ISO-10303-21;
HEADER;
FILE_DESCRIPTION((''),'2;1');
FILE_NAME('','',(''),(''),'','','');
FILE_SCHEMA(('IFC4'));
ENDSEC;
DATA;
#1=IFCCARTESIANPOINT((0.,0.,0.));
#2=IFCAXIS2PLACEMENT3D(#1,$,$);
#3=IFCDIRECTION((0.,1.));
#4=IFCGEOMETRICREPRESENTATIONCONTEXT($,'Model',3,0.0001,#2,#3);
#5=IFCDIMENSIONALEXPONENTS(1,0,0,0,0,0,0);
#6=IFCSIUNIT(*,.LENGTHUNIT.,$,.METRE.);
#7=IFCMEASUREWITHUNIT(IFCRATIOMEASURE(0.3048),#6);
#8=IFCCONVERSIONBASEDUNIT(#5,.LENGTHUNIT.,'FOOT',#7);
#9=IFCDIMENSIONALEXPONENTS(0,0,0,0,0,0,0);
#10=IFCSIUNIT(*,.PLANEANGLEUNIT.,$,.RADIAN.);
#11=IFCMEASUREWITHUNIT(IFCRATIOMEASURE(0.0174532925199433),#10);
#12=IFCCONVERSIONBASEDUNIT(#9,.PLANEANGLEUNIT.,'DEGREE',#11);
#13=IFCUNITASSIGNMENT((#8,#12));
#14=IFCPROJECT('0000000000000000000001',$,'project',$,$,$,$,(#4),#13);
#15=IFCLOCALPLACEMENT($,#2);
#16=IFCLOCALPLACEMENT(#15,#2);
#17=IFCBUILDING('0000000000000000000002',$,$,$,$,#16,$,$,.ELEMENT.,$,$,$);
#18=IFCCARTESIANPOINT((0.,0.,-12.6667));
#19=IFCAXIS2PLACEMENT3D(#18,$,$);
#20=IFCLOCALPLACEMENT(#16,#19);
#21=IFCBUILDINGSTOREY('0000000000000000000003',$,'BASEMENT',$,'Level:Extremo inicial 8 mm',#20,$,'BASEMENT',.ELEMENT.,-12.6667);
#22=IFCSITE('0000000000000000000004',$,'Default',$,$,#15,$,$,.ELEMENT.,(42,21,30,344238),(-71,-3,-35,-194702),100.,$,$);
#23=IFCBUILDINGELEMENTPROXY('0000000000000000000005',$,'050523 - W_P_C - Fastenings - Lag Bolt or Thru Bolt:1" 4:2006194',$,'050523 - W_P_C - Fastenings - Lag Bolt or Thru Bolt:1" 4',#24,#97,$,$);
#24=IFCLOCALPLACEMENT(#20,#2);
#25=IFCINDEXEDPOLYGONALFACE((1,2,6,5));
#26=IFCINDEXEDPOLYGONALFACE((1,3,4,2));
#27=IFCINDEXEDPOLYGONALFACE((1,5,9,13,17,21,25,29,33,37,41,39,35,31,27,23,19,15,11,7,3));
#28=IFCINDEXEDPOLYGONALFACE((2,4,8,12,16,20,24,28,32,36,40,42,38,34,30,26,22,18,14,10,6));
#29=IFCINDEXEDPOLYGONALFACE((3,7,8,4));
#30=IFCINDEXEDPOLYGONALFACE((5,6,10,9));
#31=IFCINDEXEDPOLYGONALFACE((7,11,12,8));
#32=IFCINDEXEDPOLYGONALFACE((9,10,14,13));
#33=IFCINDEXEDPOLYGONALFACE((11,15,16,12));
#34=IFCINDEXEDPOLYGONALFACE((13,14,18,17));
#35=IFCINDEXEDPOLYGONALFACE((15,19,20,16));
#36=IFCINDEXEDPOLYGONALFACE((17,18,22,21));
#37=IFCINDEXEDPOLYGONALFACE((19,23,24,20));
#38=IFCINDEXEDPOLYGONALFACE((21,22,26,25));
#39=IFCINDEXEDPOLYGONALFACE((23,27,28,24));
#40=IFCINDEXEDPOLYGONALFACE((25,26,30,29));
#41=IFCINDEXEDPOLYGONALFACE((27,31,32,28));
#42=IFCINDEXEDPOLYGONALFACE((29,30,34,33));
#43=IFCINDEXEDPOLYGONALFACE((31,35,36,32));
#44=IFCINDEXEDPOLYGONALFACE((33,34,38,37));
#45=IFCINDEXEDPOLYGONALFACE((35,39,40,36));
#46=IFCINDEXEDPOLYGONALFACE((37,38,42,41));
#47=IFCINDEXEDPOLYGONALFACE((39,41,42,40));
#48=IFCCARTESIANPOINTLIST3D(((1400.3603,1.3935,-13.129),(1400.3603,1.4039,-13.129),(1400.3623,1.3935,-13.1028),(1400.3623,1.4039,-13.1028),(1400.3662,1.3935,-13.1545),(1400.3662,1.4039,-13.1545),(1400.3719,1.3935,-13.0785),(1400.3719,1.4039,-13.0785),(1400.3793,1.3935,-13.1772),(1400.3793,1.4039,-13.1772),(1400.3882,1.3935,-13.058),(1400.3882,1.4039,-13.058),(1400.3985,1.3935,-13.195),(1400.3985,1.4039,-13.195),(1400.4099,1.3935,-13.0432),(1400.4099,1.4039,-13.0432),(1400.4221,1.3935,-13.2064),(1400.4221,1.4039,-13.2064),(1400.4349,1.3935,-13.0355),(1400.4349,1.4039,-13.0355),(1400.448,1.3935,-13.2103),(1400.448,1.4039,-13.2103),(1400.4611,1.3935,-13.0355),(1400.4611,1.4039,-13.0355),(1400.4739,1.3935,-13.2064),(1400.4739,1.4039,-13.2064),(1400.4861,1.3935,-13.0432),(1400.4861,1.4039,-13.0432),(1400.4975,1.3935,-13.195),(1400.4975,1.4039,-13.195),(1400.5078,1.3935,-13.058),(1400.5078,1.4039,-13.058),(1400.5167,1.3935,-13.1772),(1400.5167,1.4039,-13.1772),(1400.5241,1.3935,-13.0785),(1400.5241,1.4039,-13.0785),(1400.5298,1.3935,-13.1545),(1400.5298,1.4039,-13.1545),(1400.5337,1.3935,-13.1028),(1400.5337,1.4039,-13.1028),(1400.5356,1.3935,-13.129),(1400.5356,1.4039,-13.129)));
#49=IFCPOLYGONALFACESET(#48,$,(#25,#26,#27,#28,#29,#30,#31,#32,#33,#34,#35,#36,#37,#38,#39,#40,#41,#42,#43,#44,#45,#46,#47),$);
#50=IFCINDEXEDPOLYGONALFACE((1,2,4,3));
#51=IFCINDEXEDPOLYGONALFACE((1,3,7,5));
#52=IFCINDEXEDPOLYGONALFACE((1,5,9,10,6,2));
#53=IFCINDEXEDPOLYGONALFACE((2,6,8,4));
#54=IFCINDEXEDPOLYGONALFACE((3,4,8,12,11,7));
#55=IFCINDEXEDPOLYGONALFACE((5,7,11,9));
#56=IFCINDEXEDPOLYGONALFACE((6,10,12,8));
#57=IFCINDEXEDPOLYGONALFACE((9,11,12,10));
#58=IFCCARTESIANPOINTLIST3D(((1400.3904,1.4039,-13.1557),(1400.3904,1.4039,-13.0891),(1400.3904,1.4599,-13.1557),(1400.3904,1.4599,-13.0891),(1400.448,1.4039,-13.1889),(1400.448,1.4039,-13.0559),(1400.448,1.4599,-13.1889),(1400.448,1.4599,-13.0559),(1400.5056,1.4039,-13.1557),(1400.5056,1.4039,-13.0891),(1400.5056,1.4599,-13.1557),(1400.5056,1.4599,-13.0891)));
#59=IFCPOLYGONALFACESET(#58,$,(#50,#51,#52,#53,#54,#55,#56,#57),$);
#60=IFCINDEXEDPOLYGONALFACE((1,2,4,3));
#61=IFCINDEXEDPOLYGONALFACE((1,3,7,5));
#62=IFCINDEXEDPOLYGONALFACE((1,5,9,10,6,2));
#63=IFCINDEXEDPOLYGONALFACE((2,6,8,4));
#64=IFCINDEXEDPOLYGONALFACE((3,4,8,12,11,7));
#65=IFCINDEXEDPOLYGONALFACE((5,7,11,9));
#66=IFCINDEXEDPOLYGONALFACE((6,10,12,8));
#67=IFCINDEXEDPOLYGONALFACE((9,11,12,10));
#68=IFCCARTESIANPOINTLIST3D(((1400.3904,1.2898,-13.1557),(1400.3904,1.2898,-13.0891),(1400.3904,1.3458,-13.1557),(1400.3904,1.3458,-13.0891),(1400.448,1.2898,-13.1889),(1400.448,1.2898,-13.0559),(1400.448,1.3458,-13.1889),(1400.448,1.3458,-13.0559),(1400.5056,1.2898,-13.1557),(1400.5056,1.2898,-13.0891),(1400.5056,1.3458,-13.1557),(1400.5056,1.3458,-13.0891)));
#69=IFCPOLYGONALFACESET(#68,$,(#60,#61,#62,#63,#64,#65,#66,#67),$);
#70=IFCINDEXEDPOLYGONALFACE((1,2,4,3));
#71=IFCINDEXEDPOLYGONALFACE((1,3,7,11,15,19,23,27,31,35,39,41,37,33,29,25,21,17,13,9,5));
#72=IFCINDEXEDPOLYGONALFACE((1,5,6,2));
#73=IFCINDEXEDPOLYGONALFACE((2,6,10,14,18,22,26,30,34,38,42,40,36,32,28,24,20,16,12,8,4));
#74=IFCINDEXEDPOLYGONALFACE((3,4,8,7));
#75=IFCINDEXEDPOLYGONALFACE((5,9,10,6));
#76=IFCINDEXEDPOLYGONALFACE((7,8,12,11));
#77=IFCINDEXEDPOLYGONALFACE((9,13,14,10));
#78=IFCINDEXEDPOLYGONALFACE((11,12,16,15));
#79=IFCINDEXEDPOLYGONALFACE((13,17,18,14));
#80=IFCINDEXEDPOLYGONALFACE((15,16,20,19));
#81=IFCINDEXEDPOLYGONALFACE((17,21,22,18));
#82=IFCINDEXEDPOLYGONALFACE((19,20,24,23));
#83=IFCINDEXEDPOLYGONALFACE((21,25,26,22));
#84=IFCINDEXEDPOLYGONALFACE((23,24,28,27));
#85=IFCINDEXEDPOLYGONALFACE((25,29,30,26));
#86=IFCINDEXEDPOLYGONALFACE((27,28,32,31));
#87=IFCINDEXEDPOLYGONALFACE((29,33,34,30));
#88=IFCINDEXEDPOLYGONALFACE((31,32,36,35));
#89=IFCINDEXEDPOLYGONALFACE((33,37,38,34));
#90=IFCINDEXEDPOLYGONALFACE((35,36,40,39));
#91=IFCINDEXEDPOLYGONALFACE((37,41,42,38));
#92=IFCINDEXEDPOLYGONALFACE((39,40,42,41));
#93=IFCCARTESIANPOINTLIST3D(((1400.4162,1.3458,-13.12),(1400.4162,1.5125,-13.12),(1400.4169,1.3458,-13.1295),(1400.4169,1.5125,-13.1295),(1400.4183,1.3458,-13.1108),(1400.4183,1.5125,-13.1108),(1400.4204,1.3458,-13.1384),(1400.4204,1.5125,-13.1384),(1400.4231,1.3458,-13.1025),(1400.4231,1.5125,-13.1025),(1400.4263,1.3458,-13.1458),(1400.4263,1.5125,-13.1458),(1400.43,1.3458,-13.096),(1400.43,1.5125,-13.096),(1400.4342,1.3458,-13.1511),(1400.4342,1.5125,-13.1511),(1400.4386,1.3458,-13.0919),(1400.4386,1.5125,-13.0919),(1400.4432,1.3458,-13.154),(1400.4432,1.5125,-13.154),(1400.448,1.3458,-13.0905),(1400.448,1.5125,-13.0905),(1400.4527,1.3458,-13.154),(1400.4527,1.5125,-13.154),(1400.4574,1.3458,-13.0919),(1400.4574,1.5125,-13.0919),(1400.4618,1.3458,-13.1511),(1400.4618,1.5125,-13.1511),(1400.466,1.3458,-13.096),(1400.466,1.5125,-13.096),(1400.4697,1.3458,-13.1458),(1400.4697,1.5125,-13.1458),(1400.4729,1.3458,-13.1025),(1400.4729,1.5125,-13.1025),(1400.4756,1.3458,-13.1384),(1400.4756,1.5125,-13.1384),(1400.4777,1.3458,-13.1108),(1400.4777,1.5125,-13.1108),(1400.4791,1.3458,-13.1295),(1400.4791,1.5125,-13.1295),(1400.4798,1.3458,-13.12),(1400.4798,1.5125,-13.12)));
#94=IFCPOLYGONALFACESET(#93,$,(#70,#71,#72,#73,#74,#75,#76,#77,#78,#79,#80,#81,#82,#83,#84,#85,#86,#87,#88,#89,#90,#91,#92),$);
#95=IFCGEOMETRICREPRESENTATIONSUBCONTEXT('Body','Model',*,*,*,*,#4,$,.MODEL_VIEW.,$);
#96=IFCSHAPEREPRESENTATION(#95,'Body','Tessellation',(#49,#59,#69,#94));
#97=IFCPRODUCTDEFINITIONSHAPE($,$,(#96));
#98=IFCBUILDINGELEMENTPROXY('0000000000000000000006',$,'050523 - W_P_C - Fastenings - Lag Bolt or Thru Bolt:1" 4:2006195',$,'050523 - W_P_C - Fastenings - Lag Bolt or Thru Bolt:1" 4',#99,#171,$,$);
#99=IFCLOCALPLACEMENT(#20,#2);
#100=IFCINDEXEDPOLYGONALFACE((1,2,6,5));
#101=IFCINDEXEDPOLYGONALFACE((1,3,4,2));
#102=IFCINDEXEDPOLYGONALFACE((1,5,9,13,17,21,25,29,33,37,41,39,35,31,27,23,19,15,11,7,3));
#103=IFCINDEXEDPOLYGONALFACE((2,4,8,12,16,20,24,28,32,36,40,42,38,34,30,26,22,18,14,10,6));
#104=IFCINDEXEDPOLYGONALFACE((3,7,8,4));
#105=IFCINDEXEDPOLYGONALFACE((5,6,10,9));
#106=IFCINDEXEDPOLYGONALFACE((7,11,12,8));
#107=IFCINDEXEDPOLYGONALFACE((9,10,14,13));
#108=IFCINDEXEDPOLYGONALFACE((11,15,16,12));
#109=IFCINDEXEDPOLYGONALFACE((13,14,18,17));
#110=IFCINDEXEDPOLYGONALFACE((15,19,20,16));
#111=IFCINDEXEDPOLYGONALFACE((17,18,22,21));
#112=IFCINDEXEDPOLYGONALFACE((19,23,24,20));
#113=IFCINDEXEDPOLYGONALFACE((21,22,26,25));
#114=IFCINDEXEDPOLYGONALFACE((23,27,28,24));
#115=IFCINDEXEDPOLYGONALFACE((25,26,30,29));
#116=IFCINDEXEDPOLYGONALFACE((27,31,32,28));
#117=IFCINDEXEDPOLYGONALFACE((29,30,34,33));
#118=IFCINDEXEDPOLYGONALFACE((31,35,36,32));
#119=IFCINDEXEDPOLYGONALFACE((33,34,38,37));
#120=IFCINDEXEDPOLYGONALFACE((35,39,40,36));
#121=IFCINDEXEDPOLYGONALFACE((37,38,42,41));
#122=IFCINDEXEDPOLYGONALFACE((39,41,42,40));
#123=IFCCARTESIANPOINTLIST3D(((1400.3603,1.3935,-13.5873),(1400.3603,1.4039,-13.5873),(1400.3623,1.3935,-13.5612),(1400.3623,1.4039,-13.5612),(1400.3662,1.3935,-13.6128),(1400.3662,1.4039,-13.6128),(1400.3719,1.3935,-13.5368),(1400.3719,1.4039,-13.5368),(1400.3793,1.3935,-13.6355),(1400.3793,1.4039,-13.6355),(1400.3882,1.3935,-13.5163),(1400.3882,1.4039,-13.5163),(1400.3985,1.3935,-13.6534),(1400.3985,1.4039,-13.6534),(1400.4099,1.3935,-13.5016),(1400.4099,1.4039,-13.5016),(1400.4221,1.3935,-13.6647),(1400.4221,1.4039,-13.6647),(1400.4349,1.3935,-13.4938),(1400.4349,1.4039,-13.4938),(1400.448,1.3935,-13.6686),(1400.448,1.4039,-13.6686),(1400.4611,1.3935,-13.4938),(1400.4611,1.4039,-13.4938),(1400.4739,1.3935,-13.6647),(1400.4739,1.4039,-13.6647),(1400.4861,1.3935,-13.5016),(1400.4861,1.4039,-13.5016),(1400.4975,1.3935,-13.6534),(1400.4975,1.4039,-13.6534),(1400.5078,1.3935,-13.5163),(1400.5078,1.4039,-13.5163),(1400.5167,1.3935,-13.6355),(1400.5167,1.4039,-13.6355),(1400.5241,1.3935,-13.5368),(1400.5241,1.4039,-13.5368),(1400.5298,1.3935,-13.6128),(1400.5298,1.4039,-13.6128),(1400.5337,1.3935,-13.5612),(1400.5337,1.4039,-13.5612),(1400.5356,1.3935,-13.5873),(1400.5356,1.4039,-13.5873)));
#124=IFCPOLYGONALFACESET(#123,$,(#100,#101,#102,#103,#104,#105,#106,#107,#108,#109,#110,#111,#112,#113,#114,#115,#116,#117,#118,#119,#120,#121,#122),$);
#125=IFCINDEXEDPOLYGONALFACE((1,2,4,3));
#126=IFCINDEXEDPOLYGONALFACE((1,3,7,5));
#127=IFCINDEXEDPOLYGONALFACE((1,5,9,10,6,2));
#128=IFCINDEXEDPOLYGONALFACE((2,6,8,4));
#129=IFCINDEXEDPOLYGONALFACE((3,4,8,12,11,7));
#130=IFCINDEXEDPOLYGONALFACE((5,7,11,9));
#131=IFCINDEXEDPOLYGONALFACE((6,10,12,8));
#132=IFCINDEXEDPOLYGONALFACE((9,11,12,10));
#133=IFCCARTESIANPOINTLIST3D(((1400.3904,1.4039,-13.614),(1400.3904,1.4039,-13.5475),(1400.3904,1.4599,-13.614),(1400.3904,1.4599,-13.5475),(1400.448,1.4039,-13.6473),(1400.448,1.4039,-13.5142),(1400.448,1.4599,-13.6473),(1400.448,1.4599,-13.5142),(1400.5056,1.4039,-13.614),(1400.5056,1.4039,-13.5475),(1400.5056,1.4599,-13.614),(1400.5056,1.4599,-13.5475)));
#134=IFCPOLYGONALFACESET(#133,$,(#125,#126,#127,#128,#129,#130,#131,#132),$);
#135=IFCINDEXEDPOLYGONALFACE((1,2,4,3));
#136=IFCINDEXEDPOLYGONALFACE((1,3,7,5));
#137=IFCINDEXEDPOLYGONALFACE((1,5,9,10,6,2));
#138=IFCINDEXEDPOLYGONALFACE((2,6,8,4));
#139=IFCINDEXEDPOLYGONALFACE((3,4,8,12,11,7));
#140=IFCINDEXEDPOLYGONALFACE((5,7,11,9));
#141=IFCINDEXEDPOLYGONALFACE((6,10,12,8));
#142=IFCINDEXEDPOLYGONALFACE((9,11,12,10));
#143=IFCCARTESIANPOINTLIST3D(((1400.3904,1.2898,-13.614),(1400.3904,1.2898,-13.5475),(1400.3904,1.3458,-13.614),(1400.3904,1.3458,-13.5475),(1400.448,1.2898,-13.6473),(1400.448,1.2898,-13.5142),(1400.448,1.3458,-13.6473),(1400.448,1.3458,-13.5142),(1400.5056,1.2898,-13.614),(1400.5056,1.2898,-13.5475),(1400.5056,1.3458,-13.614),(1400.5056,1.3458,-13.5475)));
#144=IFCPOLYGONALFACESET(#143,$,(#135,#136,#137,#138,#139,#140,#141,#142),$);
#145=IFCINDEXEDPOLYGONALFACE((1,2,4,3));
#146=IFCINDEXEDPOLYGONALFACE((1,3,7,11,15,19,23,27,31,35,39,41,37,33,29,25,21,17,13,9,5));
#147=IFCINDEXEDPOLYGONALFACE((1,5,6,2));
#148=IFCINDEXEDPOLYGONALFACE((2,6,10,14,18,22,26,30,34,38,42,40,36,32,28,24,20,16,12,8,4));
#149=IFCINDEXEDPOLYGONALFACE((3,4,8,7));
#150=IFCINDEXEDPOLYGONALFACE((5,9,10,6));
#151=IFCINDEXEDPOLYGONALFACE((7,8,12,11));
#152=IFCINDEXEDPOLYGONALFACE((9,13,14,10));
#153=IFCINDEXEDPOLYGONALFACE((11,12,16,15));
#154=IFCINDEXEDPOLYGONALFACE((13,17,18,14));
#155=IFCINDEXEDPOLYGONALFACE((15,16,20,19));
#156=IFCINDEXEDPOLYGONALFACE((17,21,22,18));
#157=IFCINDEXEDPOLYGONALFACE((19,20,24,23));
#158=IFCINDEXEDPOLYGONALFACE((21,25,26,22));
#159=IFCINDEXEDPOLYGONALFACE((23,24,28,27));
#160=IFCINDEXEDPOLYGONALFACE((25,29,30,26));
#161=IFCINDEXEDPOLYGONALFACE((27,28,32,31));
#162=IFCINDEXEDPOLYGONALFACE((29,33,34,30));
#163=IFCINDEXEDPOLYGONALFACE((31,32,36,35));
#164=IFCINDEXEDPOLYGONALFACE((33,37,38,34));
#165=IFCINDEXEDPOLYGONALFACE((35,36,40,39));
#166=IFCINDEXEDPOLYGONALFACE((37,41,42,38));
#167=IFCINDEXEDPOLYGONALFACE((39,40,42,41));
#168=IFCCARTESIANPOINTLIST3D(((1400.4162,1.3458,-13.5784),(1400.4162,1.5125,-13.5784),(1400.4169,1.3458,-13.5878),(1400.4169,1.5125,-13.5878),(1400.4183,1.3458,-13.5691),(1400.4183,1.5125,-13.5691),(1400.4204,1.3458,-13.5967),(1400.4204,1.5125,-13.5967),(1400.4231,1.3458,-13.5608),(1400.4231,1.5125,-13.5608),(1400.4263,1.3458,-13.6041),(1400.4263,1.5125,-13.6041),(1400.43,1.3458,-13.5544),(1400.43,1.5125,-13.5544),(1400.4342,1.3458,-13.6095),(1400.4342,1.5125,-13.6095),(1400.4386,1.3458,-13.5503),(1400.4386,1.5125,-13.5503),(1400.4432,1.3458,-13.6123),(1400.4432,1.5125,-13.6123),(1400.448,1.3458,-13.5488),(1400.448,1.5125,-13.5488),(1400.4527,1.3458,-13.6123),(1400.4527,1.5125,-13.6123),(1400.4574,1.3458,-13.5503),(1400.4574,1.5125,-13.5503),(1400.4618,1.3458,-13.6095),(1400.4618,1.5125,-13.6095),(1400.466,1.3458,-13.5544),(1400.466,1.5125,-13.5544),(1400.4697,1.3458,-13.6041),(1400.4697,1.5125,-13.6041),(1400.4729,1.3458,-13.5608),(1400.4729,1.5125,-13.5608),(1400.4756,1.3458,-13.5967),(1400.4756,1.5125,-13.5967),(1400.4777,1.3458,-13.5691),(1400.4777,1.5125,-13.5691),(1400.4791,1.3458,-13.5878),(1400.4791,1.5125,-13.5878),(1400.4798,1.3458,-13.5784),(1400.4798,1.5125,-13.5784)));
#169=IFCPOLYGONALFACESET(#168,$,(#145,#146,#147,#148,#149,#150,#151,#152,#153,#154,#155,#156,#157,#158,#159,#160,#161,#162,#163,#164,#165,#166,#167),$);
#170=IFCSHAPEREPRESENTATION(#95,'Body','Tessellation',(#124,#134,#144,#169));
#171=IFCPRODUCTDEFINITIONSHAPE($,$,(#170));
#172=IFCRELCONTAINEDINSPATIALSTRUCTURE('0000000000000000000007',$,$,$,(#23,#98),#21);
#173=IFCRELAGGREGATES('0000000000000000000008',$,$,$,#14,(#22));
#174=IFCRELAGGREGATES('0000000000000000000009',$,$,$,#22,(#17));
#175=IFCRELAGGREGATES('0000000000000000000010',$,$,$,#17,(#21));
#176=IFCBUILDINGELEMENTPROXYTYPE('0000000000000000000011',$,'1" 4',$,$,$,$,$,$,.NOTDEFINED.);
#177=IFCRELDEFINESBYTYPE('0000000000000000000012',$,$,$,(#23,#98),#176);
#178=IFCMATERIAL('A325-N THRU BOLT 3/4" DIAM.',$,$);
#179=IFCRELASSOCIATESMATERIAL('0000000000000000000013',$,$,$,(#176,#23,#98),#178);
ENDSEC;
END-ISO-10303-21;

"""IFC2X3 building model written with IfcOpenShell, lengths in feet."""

from ifc_helpers import new_model, entity, si_unit, converted_unit, direction, frame, frame_2d, origin, place, context, subcontext, project, spatial, polyline, circle, outline, extrude, source, transform, mapped, material, type_object, type_shapes, element, save


model = new_model("IFC2X3")

# Units and contexts
model_context = context("Model", 3, precision=0.0001, world=origin(), true_north=direction((0.0, 1.0)))
body_context = subcontext(model_context, "Body", "Model", "MODEL_VIEW")
ifc_project = project(units=[converted_unit("LENGTHUNIT", "FOOT", entity("IfcRatioMeasure", 0.3048), si_unit("LENGTHUNIT", "METRE"), dimensions=[1, 0, 0, 0, 0, 0, 0]), converted_unit("PLANEANGLEUNIT", "DEGREE", entity("IfcRatioMeasure", 0.0174532925199433), si_unit("PLANEANGLEUNIT", "RADIAN"), dimensions=[0, 0, 0, 0, 0, 0, 0])], contexts=[model_context])

# Site, building, storey
site_placement = place(None, origin())
site = spatial("IfcSite", under=ifc_project, at=site_placement, Name="Default", CompositionType="ELEMENT", RefLatitude=(42, 21, 30, 344238), RefLongitude=(-71, -3, -35, -194702), RefElevation=100.0)
building_placement = place(site_placement, origin())
building = spatial("IfcBuilding", under=site, at=building_placement, CompositionType="ELEMENT")
storey_placement = place(building_placement, frame((0.0, 0.0, -12.6667)))
storey = spatial("IfcBuildingStorey", under=building, at=storey_placement, Name="BASEMENT", ObjectType="Level:Extremo inicial 8 mm", LongName="BASEMENT", CompositionType="ELEMENT", Elevation=-12.6667)

# Building element proxies
ifc_material_1 = material(Name="A325-N THRU BOLT 3/4\" DIAM.")
building_element_proxy_type_1 = type_object("IfcBuildingElementProxyType", Name="1\" 4", PredefinedType="NOTDEFINED", material=ifc_material_1)
shared_shape_1 = source(origin(), body_context, "Body", "SweptSolid", [
    extrude(circle(Radius=0.0879, at=frame_2d((0.0, 0.0), x_axis=(1.0, 0.0))), frame((0.0, 0.0, -0.0581), z_axis=(0.0, 0.0, 1.0), x_axis=(0.0, -1.0, 0.0)), (0.0, 0.0, 1.0), 0.0104),
    extrude(outline(polyline([(-0.0333, -0.0576), (0.0333, -0.0576), (0.0665, 0.0), (0.0333, 0.0576), (-0.0333, 0.0576), (-0.0665, 0.0), (-0.0333, -0.0576)])), frame((0.0, 0.0, -0.1141), z_axis=(0.0, 0.0, 1.0), x_axis=(0.866025, -0.5, 0.0)), (0.0, 0.0, 1.0), 0.056),
    extrude(outline(polyline([(-0.0333, -0.0576), (0.0333, -0.0576), (0.0665, 0.0), (0.0333, 0.0576), (-0.0333, 0.0576), (-0.0665, 0.0), (-0.0333, -0.0576)])), frame((0.0, 0.0, 0.0), z_axis=(0.0, 0.0, 1.0), x_axis=(0.0, -1.0, 0.0)), (0.0, 0.0, 1.0), 0.056),
    extrude(circle(Radius=0.0319, at=frame_2d((0.0, 0.0), x_axis=(1.0, 0.0))), frame((0.0, 0.0, -0.1667), z_axis=(0.0, 0.0, 1.0), x_axis=(0.0, 1.0, 0.0)), (0.0, 0.0, 1.0), 0.1667),
])
type_shapes(building_element_proxy_type_1, [shared_shape_1])
for number, where, z_axis, x_axis, name in (
    (1, (1400.448, 1.3458, -13.1224), (0.0, -1.0, 0.0), (1.0, 0.0, 0.0), "050523 - W_P_C - Fastenings - Lag Bolt or Thru Bolt:1\" 4:2006194"),
    (2, (1400.448, 1.3458, -13.5807), (0.0, -1.0, 0.0), (1.0, 0.0, 0.0), "050523 - W_P_C - Fastenings - Lag Bolt or Thru Bolt:1\" 4:2006195"),
):
    element("IfcBuildingElementProxy", number, at=place(storey_placement, frame(where, z_axis=z_axis, x_axis=x_axis)), inside=storey, type_object=building_element_proxy_type_1, material=ifc_material_1, Name=name, ObjectType="050523 - W_P_C - Fastenings - Lag Bolt or Thru Bolt:1\" 4", context=body_context, shape_type="MappedRepresentation", body=[
        mapped(shared_shape_1, transform((0.0, 0.0, 0.0), scale=1.0)),
    ])

save(model, "model.ifc")
